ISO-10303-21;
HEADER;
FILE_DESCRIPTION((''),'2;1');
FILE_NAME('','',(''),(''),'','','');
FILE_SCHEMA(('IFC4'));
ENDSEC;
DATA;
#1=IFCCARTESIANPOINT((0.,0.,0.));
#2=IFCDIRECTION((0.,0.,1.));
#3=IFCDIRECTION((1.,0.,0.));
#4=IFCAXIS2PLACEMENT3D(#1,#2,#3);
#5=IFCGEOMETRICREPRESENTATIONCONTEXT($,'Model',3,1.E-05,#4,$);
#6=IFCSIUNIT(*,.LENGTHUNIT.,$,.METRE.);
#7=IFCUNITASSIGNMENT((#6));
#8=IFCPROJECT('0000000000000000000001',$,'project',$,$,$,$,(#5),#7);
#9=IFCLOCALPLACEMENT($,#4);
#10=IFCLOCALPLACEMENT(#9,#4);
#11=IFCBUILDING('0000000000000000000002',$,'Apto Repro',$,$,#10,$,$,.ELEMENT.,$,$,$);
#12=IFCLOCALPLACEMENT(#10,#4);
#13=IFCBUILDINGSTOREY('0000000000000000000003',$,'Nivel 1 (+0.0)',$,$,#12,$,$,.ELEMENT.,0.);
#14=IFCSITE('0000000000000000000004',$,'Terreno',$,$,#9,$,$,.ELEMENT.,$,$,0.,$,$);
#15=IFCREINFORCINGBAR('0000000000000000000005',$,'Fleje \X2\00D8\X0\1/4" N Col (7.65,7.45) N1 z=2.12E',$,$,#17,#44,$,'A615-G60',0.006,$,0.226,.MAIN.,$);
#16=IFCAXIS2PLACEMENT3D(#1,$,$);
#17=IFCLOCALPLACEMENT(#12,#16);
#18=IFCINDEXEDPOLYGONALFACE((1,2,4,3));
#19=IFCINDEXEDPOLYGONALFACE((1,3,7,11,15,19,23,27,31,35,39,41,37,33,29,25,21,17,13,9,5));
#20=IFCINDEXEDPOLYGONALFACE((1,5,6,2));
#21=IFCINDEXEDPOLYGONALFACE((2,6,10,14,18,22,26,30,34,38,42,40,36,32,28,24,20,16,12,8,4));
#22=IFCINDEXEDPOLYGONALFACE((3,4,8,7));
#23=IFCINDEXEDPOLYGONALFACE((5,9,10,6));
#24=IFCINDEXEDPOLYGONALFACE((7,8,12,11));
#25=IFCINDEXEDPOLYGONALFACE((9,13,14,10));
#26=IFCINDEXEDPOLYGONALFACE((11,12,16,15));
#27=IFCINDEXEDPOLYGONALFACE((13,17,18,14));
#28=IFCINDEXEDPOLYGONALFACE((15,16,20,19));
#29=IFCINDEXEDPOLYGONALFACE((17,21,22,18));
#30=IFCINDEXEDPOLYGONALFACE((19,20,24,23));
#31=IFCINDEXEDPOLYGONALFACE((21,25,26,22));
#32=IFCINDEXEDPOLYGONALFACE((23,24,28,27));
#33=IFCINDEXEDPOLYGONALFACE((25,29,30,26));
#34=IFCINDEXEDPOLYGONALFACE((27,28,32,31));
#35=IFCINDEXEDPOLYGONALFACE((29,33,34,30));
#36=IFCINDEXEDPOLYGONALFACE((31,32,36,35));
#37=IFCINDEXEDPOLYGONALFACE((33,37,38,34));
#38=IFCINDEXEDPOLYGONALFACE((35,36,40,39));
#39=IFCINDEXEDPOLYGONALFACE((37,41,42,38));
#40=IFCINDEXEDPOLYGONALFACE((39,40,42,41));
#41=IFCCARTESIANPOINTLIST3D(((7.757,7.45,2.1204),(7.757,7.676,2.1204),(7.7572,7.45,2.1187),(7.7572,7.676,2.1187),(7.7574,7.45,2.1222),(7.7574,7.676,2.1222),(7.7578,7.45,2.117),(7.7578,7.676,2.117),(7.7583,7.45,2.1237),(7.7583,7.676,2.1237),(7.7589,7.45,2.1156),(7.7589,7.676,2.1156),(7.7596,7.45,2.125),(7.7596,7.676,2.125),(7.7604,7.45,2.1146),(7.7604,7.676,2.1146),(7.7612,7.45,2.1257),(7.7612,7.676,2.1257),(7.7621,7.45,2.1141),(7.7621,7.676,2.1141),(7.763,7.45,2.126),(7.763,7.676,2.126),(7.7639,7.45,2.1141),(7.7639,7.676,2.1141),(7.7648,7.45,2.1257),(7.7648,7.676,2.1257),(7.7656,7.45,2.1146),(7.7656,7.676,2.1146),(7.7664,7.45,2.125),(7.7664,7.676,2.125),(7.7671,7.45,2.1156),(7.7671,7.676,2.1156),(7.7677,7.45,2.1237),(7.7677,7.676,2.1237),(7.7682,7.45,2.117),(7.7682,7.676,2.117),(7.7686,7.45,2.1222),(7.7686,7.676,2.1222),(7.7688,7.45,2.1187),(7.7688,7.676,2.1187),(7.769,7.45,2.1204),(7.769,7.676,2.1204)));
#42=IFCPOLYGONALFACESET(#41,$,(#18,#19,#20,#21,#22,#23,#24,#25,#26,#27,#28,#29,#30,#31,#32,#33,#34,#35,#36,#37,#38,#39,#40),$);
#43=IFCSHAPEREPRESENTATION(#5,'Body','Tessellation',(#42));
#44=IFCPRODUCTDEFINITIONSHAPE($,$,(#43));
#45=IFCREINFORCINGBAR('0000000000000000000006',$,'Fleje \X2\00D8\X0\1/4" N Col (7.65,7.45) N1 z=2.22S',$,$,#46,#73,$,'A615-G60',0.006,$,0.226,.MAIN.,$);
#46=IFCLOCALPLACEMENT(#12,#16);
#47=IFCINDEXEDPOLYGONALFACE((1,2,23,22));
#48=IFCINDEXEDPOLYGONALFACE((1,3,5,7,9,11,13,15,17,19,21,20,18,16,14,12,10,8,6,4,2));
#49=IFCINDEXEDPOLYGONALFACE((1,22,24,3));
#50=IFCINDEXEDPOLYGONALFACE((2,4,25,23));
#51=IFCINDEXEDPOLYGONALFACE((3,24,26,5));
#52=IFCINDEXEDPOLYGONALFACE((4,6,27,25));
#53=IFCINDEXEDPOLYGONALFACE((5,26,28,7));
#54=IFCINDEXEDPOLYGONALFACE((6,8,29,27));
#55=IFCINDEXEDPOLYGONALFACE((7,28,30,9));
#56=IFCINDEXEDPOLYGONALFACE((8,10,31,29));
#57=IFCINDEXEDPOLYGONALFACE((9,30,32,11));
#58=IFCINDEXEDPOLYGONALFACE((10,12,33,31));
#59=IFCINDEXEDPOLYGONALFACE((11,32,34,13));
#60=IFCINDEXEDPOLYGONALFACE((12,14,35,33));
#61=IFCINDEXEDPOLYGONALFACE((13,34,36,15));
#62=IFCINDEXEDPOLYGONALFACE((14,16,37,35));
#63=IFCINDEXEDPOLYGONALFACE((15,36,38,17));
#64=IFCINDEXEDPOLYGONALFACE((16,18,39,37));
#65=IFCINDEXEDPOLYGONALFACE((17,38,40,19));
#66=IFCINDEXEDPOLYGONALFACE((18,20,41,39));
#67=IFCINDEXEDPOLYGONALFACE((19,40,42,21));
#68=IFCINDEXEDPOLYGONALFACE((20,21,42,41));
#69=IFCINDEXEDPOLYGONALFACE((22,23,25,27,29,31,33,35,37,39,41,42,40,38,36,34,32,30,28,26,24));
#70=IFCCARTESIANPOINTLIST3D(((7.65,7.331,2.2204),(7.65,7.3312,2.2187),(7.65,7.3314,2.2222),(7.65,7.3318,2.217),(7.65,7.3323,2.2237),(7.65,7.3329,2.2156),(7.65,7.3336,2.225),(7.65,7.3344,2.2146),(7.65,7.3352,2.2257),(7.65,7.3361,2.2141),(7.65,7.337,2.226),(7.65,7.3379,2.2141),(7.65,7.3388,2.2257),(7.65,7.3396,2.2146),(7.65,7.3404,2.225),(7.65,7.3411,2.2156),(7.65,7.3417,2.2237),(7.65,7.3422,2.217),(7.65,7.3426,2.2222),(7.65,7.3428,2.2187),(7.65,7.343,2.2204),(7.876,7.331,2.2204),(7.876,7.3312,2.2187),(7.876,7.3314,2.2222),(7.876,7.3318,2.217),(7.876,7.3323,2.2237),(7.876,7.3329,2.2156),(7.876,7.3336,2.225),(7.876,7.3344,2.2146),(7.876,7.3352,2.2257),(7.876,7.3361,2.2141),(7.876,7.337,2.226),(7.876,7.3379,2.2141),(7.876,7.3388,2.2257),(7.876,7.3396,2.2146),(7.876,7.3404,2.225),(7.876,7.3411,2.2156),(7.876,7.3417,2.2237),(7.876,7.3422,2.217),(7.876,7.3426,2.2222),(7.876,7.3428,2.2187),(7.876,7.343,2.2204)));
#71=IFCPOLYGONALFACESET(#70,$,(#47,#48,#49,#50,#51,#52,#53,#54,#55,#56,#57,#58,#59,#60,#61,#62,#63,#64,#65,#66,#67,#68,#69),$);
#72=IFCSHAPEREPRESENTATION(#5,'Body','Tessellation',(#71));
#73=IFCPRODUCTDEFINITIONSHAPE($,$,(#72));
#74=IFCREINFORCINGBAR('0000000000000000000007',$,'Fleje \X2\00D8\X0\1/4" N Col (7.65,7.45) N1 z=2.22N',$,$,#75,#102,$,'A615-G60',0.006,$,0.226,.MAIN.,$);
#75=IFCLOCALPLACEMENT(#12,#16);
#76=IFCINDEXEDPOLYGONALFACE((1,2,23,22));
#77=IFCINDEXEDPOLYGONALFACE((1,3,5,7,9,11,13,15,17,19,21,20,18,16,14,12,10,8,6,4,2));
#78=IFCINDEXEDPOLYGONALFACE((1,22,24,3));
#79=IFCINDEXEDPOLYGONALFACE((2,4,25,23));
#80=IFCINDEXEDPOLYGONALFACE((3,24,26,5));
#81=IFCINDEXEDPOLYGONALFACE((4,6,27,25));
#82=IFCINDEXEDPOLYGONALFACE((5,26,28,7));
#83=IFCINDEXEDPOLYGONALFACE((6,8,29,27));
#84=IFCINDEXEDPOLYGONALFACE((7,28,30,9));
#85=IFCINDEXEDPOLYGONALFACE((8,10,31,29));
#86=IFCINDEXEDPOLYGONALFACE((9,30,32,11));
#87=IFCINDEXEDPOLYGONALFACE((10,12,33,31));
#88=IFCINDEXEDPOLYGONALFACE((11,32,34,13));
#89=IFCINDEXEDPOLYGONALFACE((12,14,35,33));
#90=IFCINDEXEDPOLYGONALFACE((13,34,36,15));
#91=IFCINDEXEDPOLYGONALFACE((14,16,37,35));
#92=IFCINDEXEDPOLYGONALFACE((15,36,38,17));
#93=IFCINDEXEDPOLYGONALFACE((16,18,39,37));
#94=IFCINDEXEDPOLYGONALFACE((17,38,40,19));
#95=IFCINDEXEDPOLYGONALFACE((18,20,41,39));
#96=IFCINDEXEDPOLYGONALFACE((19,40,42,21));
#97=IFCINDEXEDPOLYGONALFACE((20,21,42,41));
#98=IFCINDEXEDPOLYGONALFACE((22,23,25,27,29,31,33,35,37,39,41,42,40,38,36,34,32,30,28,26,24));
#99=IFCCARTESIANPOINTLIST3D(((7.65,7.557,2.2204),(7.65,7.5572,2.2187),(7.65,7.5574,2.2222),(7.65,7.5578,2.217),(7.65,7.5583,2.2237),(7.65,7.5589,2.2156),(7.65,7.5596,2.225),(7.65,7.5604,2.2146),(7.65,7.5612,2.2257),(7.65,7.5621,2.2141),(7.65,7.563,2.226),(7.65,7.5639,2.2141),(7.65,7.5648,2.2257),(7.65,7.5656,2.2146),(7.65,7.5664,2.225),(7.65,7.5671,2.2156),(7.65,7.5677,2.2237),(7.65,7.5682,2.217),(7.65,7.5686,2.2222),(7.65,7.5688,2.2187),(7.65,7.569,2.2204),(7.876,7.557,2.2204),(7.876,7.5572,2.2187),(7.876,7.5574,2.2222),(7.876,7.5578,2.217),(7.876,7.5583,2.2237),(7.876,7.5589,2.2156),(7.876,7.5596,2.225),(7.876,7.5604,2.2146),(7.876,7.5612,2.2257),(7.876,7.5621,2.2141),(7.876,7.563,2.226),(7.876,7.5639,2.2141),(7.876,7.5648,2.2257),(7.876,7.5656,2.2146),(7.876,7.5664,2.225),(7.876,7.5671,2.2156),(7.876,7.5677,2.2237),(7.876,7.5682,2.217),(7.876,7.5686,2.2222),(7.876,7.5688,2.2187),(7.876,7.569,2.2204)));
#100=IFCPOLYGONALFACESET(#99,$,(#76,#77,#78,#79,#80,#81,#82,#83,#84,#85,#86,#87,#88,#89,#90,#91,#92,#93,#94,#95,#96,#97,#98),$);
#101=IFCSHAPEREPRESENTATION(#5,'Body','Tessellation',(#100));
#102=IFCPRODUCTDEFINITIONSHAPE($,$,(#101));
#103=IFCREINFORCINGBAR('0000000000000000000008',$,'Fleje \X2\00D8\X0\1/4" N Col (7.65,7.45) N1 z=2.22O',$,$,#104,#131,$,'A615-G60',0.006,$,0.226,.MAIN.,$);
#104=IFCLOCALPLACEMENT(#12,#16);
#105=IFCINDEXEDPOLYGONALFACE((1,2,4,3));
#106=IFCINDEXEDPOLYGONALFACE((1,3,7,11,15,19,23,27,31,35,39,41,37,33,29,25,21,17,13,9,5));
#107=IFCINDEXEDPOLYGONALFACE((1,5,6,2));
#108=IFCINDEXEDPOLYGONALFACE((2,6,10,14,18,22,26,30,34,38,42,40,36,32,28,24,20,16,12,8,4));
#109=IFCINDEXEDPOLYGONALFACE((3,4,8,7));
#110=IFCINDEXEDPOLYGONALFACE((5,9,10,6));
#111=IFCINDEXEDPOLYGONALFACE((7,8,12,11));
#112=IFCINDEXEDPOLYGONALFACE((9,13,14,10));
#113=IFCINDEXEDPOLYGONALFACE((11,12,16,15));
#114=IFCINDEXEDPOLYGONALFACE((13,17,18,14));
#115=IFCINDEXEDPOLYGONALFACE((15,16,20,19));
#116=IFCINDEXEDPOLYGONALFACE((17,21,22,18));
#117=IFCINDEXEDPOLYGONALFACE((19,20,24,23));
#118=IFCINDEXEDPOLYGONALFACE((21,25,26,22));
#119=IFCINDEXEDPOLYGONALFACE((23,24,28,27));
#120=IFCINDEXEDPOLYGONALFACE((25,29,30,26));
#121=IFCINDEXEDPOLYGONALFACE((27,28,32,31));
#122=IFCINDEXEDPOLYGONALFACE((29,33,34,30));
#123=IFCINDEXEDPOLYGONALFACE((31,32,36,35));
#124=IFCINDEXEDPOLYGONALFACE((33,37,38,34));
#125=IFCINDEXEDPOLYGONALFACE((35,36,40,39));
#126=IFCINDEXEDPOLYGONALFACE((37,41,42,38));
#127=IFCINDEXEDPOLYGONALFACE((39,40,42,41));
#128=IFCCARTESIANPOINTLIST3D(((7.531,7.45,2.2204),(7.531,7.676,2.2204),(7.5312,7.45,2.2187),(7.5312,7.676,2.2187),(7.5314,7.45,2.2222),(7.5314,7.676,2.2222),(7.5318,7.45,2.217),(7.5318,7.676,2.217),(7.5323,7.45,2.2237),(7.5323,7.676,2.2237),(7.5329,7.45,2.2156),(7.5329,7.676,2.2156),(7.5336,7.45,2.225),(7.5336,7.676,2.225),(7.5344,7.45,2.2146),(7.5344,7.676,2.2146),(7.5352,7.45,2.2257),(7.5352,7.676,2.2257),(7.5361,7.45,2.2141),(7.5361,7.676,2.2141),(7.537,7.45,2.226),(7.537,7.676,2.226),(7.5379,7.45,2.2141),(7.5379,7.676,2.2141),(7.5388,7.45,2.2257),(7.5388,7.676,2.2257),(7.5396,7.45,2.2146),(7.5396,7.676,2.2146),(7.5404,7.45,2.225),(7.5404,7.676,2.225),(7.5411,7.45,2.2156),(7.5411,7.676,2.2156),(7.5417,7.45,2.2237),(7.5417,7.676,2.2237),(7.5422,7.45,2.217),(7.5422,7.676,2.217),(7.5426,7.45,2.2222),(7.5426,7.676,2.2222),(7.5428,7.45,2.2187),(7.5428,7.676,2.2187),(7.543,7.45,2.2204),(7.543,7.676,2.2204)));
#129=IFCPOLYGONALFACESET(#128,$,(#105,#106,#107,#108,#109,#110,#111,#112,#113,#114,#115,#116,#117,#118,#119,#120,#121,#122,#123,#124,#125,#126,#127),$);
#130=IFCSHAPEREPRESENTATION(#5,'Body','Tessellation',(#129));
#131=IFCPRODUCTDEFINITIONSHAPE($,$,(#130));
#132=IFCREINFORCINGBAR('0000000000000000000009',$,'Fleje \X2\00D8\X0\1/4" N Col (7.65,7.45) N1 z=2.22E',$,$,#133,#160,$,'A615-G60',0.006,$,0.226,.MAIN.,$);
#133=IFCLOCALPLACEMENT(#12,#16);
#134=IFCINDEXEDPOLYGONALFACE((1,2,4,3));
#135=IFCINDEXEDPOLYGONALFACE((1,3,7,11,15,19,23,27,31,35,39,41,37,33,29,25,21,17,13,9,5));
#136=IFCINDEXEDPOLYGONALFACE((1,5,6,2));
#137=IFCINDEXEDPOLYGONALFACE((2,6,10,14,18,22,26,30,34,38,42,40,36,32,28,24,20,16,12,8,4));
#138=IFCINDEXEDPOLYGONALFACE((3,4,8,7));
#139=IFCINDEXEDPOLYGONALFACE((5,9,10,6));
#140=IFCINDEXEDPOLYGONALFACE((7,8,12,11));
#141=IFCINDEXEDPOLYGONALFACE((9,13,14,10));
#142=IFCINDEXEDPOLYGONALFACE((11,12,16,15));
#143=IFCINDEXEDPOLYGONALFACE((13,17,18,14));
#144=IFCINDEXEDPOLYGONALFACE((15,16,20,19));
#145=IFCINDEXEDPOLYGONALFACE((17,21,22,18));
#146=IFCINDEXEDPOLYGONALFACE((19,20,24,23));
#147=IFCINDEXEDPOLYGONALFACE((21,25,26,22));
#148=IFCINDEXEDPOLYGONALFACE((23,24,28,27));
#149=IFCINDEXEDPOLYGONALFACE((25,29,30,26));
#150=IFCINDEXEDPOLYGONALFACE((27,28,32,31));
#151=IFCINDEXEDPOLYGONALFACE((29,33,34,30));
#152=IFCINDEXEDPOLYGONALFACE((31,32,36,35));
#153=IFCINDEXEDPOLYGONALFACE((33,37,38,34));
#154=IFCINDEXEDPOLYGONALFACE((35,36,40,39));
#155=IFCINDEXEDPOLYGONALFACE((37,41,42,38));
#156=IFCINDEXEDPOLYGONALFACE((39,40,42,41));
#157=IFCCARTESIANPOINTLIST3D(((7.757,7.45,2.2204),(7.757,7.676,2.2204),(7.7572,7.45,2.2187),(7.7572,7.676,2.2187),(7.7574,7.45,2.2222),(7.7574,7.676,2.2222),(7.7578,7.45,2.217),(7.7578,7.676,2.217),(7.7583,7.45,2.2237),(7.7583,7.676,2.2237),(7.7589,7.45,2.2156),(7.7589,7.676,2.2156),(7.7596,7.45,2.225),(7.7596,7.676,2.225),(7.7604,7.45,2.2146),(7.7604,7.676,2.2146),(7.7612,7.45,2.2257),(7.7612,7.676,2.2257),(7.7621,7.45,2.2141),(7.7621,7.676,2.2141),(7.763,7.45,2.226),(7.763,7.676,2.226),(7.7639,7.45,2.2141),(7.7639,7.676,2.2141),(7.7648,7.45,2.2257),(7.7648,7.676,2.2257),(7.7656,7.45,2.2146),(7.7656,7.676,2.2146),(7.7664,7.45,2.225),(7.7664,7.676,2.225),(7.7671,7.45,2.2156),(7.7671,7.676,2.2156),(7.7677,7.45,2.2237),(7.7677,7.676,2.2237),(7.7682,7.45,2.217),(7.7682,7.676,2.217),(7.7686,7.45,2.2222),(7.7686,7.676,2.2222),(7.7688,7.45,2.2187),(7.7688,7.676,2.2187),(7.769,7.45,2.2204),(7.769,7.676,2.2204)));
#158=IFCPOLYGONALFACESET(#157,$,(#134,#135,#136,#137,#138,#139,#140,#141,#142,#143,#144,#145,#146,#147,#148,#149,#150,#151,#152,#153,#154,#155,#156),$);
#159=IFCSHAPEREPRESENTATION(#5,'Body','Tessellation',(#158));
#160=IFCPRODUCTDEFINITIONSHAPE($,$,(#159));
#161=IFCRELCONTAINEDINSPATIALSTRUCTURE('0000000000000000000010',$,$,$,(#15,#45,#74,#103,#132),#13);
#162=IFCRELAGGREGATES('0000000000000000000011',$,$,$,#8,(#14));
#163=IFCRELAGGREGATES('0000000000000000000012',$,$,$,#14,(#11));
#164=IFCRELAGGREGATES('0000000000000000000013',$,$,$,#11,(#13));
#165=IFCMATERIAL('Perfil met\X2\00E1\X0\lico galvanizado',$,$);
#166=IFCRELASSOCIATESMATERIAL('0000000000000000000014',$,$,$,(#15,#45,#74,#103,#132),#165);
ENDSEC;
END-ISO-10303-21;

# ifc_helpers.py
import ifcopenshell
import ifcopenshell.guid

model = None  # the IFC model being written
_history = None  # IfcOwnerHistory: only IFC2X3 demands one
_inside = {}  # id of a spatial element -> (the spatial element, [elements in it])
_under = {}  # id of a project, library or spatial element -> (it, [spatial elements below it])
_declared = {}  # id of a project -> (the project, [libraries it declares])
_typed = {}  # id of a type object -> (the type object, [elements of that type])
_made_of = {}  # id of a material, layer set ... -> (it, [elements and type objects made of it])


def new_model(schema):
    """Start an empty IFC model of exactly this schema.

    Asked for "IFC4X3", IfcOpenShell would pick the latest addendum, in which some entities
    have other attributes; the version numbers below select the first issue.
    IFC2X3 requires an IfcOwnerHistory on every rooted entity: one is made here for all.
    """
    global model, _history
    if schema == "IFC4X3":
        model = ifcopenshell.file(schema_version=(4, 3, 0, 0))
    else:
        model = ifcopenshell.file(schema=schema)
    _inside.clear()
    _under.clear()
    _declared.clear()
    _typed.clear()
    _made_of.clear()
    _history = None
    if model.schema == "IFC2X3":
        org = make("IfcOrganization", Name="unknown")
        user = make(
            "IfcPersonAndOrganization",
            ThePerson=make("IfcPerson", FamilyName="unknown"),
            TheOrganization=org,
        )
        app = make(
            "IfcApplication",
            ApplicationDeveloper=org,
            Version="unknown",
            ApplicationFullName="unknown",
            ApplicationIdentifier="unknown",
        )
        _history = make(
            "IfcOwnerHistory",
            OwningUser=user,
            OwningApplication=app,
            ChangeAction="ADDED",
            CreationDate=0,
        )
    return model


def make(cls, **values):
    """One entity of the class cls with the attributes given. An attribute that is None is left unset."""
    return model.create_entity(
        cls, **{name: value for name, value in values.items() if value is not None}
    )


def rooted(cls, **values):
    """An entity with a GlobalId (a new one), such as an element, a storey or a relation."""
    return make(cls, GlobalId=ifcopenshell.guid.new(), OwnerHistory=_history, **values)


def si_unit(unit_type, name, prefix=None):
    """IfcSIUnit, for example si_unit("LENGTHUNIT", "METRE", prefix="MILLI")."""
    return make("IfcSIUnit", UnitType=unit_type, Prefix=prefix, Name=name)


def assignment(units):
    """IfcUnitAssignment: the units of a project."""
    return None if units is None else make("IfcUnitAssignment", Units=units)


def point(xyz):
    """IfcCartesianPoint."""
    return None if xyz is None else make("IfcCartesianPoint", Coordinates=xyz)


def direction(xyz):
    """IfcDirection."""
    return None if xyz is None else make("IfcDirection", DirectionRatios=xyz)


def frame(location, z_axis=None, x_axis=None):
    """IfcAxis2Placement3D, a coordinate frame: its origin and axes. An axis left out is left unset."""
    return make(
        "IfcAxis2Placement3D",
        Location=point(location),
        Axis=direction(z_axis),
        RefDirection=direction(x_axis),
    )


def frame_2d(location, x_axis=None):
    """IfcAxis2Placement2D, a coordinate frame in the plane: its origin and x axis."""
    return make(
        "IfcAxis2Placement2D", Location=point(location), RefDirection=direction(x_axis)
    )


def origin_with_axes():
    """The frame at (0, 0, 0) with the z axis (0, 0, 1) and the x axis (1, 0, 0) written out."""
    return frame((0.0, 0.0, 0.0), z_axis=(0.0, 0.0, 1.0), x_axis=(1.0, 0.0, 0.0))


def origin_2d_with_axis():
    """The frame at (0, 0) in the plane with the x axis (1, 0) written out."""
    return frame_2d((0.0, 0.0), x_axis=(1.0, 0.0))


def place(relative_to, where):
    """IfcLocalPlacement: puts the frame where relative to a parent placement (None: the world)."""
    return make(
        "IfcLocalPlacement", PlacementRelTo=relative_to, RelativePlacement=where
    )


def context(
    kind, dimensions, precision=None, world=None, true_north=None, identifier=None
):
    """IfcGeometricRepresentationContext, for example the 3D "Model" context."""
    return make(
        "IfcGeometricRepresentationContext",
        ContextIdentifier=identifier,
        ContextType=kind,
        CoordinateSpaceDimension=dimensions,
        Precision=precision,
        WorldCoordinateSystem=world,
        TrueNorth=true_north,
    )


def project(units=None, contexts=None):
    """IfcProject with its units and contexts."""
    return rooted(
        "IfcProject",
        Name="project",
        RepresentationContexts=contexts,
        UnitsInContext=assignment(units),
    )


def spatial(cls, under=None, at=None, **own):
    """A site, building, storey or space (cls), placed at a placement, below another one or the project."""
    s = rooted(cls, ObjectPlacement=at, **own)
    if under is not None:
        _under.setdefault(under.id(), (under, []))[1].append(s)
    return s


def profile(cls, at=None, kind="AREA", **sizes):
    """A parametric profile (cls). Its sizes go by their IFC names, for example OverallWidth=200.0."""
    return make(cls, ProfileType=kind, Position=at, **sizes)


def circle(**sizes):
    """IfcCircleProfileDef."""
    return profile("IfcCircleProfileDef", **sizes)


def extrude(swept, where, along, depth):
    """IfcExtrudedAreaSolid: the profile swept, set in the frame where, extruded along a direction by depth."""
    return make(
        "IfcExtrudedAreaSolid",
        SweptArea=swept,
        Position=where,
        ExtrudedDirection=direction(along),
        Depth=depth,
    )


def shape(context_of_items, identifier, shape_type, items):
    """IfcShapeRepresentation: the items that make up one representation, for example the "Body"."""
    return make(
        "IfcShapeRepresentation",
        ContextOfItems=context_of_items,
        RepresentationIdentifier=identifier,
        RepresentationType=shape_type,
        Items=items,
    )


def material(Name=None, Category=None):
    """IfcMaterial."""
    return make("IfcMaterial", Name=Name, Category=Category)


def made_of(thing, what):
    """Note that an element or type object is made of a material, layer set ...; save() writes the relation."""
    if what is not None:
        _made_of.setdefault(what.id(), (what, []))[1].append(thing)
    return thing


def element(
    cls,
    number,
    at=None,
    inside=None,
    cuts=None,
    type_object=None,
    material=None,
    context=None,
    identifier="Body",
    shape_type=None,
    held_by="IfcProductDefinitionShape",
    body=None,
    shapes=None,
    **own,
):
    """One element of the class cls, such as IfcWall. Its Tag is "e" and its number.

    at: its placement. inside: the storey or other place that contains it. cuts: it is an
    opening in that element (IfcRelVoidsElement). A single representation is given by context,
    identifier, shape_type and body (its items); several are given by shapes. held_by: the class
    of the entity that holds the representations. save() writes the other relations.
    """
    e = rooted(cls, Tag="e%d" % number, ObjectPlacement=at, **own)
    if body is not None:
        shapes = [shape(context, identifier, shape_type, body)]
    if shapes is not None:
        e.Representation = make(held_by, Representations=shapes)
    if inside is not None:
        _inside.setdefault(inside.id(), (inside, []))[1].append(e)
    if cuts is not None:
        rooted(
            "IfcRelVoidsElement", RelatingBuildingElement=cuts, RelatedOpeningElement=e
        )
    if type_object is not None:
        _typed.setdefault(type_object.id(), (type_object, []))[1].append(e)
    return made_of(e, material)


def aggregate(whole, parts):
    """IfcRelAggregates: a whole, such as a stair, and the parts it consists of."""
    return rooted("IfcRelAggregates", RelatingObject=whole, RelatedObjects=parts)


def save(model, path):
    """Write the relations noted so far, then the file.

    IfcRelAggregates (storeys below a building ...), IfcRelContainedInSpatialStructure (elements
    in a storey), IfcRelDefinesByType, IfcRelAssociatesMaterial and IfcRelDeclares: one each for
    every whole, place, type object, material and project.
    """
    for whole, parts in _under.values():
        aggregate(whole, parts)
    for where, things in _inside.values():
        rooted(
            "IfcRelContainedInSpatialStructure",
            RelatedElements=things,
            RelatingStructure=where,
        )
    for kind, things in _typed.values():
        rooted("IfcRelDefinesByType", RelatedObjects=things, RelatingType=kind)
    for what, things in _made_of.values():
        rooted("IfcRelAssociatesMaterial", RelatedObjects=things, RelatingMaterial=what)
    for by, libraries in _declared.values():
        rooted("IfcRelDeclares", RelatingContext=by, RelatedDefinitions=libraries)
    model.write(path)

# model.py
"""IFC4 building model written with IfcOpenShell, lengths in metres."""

from ifc_helpers import new_model, si_unit, frame, origin_with_axes, origin_2d_with_axis, place, context, project, spatial, circle, extrude, material, element, save


model = new_model("IFC4")

# Units and contexts
model_context = context("Model", 3, precision=1e-05, world=origin_with_axes())
ifc_project = project(units=[si_unit("LENGTHUNIT", "METRE")], contexts=[model_context])

# Site, building, storey
site_placement = place(None, origin_with_axes())
site = spatial("IfcSite", under=ifc_project, at=site_placement, Name="Terreno", CompositionType="ELEMENT", RefElevation=0.0)
building_placement = place(site_placement, origin_with_axes())
building = spatial("IfcBuilding", under=site, at=building_placement, Name="Apto Repro", CompositionType="ELEMENT")
storey_placement = place(building_placement, origin_with_axes())
storey = spatial("IfcBuildingStorey", under=building, at=storey_placement, Name="Nivel 1 (+0.0)", CompositionType="ELEMENT", Elevation=0.0)

# Reinforcing bars
ifc_material = material(Name="Perfil metálico galvanizado")
reinforcing_bar_1_placement = place(storey_placement, origin_with_axes())
element("IfcReinforcingBar", 1, at=reinforcing_bar_1_placement, inside=storey, material=ifc_material, Name="Fleje Ø1/4\" N Col (7.65,7.45) N1 z=2.12E", SteelGrade="A615-G60", BarLength=0.226, NominalDiameter=0.006, PredefinedType="MAIN", context=model_context, shape_type="SweptSolid", body=[
    extrude(circle(Radius=0.006, at=origin_2d_with_axis()), frame((7.763, 7.45, 2.12), z_axis=(0.0, 1.0, 0.0), x_axis=(0.0, 0.0, 1.0)), (0.0, 0.0, 1.0), 0.226),
])
reinforcing_bar_2_placement = place(storey_placement, origin_with_axes())
element("IfcReinforcingBar", 2, at=reinforcing_bar_2_placement, inside=storey, material=ifc_material, Name="Fleje Ø1/4\" N Col (7.65,7.45) N1 z=2.22S", SteelGrade="A615-G60", BarLength=0.226, NominalDiameter=0.006, PredefinedType="MAIN", context=model_context, shape_type="SweptSolid", body=[
    extrude(circle(Radius=0.006, at=origin_2d_with_axis()), frame((7.65, 7.337, 2.22), z_axis=(1.0, 0.0, 0.0), x_axis=(0.0, 0.0, 1.0)), (0.0, 0.0, 1.0), 0.226),
])
reinforcing_bar_3_placement = place(storey_placement, origin_with_axes())
element("IfcReinforcingBar", 3, at=reinforcing_bar_3_placement, inside=storey, material=ifc_material, Name="Fleje Ø1/4\" N Col (7.65,7.45) N1 z=2.22N", SteelGrade="A615-G60", BarLength=0.226, NominalDiameter=0.006, PredefinedType="MAIN", context=model_context, shape_type="SweptSolid", body=[
    extrude(circle(Radius=0.006, at=origin_2d_with_axis()), frame((7.65, 7.563, 2.22), z_axis=(1.0, 0.0, 0.0), x_axis=(0.0, 0.0, 1.0)), (0.0, 0.0, 1.0), 0.226),
])
reinforcing_bar_4_placement = place(storey_placement, origin_with_axes())
element("IfcReinforcingBar", 4, at=reinforcing_bar_4_placement, inside=storey, material=ifc_material, Name="Fleje Ø1/4\" N Col (7.65,7.45) N1 z=2.22O", SteelGrade="A615-G60", BarLength=0.226, NominalDiameter=0.006, PredefinedType="MAIN", context=model_context, shape_type="SweptSolid", body=[
    extrude(circle(Radius=0.006, at=origin_2d_with_axis()), frame((7.537, 7.45, 2.22), z_axis=(0.0, 1.0, 0.0), x_axis=(0.0, 0.0, 1.0)), (0.0, 0.0, 1.0), 0.226),
])
reinforcing_bar_5_placement = place(storey_placement, origin_with_axes())
element("IfcReinforcingBar", 5, at=reinforcing_bar_5_placement, inside=storey, material=ifc_material, Name="Fleje Ø1/4\" N Col (7.65,7.45) N1 z=2.22E", SteelGrade="A615-G60", BarLength=0.226, NominalDiameter=0.006, PredefinedType="MAIN", context=model_context, shape_type="SweptSolid", body=[
    extrude(circle(Radius=0.006, at=origin_2d_with_axis()), frame((7.763, 7.45, 2.22), z_axis=(0.0, 1.0, 0.0), x_axis=(0.0, 0.0, 1.0)), (0.0, 0.0, 1.0), 0.226),
])

save(model, "model.ifc")
